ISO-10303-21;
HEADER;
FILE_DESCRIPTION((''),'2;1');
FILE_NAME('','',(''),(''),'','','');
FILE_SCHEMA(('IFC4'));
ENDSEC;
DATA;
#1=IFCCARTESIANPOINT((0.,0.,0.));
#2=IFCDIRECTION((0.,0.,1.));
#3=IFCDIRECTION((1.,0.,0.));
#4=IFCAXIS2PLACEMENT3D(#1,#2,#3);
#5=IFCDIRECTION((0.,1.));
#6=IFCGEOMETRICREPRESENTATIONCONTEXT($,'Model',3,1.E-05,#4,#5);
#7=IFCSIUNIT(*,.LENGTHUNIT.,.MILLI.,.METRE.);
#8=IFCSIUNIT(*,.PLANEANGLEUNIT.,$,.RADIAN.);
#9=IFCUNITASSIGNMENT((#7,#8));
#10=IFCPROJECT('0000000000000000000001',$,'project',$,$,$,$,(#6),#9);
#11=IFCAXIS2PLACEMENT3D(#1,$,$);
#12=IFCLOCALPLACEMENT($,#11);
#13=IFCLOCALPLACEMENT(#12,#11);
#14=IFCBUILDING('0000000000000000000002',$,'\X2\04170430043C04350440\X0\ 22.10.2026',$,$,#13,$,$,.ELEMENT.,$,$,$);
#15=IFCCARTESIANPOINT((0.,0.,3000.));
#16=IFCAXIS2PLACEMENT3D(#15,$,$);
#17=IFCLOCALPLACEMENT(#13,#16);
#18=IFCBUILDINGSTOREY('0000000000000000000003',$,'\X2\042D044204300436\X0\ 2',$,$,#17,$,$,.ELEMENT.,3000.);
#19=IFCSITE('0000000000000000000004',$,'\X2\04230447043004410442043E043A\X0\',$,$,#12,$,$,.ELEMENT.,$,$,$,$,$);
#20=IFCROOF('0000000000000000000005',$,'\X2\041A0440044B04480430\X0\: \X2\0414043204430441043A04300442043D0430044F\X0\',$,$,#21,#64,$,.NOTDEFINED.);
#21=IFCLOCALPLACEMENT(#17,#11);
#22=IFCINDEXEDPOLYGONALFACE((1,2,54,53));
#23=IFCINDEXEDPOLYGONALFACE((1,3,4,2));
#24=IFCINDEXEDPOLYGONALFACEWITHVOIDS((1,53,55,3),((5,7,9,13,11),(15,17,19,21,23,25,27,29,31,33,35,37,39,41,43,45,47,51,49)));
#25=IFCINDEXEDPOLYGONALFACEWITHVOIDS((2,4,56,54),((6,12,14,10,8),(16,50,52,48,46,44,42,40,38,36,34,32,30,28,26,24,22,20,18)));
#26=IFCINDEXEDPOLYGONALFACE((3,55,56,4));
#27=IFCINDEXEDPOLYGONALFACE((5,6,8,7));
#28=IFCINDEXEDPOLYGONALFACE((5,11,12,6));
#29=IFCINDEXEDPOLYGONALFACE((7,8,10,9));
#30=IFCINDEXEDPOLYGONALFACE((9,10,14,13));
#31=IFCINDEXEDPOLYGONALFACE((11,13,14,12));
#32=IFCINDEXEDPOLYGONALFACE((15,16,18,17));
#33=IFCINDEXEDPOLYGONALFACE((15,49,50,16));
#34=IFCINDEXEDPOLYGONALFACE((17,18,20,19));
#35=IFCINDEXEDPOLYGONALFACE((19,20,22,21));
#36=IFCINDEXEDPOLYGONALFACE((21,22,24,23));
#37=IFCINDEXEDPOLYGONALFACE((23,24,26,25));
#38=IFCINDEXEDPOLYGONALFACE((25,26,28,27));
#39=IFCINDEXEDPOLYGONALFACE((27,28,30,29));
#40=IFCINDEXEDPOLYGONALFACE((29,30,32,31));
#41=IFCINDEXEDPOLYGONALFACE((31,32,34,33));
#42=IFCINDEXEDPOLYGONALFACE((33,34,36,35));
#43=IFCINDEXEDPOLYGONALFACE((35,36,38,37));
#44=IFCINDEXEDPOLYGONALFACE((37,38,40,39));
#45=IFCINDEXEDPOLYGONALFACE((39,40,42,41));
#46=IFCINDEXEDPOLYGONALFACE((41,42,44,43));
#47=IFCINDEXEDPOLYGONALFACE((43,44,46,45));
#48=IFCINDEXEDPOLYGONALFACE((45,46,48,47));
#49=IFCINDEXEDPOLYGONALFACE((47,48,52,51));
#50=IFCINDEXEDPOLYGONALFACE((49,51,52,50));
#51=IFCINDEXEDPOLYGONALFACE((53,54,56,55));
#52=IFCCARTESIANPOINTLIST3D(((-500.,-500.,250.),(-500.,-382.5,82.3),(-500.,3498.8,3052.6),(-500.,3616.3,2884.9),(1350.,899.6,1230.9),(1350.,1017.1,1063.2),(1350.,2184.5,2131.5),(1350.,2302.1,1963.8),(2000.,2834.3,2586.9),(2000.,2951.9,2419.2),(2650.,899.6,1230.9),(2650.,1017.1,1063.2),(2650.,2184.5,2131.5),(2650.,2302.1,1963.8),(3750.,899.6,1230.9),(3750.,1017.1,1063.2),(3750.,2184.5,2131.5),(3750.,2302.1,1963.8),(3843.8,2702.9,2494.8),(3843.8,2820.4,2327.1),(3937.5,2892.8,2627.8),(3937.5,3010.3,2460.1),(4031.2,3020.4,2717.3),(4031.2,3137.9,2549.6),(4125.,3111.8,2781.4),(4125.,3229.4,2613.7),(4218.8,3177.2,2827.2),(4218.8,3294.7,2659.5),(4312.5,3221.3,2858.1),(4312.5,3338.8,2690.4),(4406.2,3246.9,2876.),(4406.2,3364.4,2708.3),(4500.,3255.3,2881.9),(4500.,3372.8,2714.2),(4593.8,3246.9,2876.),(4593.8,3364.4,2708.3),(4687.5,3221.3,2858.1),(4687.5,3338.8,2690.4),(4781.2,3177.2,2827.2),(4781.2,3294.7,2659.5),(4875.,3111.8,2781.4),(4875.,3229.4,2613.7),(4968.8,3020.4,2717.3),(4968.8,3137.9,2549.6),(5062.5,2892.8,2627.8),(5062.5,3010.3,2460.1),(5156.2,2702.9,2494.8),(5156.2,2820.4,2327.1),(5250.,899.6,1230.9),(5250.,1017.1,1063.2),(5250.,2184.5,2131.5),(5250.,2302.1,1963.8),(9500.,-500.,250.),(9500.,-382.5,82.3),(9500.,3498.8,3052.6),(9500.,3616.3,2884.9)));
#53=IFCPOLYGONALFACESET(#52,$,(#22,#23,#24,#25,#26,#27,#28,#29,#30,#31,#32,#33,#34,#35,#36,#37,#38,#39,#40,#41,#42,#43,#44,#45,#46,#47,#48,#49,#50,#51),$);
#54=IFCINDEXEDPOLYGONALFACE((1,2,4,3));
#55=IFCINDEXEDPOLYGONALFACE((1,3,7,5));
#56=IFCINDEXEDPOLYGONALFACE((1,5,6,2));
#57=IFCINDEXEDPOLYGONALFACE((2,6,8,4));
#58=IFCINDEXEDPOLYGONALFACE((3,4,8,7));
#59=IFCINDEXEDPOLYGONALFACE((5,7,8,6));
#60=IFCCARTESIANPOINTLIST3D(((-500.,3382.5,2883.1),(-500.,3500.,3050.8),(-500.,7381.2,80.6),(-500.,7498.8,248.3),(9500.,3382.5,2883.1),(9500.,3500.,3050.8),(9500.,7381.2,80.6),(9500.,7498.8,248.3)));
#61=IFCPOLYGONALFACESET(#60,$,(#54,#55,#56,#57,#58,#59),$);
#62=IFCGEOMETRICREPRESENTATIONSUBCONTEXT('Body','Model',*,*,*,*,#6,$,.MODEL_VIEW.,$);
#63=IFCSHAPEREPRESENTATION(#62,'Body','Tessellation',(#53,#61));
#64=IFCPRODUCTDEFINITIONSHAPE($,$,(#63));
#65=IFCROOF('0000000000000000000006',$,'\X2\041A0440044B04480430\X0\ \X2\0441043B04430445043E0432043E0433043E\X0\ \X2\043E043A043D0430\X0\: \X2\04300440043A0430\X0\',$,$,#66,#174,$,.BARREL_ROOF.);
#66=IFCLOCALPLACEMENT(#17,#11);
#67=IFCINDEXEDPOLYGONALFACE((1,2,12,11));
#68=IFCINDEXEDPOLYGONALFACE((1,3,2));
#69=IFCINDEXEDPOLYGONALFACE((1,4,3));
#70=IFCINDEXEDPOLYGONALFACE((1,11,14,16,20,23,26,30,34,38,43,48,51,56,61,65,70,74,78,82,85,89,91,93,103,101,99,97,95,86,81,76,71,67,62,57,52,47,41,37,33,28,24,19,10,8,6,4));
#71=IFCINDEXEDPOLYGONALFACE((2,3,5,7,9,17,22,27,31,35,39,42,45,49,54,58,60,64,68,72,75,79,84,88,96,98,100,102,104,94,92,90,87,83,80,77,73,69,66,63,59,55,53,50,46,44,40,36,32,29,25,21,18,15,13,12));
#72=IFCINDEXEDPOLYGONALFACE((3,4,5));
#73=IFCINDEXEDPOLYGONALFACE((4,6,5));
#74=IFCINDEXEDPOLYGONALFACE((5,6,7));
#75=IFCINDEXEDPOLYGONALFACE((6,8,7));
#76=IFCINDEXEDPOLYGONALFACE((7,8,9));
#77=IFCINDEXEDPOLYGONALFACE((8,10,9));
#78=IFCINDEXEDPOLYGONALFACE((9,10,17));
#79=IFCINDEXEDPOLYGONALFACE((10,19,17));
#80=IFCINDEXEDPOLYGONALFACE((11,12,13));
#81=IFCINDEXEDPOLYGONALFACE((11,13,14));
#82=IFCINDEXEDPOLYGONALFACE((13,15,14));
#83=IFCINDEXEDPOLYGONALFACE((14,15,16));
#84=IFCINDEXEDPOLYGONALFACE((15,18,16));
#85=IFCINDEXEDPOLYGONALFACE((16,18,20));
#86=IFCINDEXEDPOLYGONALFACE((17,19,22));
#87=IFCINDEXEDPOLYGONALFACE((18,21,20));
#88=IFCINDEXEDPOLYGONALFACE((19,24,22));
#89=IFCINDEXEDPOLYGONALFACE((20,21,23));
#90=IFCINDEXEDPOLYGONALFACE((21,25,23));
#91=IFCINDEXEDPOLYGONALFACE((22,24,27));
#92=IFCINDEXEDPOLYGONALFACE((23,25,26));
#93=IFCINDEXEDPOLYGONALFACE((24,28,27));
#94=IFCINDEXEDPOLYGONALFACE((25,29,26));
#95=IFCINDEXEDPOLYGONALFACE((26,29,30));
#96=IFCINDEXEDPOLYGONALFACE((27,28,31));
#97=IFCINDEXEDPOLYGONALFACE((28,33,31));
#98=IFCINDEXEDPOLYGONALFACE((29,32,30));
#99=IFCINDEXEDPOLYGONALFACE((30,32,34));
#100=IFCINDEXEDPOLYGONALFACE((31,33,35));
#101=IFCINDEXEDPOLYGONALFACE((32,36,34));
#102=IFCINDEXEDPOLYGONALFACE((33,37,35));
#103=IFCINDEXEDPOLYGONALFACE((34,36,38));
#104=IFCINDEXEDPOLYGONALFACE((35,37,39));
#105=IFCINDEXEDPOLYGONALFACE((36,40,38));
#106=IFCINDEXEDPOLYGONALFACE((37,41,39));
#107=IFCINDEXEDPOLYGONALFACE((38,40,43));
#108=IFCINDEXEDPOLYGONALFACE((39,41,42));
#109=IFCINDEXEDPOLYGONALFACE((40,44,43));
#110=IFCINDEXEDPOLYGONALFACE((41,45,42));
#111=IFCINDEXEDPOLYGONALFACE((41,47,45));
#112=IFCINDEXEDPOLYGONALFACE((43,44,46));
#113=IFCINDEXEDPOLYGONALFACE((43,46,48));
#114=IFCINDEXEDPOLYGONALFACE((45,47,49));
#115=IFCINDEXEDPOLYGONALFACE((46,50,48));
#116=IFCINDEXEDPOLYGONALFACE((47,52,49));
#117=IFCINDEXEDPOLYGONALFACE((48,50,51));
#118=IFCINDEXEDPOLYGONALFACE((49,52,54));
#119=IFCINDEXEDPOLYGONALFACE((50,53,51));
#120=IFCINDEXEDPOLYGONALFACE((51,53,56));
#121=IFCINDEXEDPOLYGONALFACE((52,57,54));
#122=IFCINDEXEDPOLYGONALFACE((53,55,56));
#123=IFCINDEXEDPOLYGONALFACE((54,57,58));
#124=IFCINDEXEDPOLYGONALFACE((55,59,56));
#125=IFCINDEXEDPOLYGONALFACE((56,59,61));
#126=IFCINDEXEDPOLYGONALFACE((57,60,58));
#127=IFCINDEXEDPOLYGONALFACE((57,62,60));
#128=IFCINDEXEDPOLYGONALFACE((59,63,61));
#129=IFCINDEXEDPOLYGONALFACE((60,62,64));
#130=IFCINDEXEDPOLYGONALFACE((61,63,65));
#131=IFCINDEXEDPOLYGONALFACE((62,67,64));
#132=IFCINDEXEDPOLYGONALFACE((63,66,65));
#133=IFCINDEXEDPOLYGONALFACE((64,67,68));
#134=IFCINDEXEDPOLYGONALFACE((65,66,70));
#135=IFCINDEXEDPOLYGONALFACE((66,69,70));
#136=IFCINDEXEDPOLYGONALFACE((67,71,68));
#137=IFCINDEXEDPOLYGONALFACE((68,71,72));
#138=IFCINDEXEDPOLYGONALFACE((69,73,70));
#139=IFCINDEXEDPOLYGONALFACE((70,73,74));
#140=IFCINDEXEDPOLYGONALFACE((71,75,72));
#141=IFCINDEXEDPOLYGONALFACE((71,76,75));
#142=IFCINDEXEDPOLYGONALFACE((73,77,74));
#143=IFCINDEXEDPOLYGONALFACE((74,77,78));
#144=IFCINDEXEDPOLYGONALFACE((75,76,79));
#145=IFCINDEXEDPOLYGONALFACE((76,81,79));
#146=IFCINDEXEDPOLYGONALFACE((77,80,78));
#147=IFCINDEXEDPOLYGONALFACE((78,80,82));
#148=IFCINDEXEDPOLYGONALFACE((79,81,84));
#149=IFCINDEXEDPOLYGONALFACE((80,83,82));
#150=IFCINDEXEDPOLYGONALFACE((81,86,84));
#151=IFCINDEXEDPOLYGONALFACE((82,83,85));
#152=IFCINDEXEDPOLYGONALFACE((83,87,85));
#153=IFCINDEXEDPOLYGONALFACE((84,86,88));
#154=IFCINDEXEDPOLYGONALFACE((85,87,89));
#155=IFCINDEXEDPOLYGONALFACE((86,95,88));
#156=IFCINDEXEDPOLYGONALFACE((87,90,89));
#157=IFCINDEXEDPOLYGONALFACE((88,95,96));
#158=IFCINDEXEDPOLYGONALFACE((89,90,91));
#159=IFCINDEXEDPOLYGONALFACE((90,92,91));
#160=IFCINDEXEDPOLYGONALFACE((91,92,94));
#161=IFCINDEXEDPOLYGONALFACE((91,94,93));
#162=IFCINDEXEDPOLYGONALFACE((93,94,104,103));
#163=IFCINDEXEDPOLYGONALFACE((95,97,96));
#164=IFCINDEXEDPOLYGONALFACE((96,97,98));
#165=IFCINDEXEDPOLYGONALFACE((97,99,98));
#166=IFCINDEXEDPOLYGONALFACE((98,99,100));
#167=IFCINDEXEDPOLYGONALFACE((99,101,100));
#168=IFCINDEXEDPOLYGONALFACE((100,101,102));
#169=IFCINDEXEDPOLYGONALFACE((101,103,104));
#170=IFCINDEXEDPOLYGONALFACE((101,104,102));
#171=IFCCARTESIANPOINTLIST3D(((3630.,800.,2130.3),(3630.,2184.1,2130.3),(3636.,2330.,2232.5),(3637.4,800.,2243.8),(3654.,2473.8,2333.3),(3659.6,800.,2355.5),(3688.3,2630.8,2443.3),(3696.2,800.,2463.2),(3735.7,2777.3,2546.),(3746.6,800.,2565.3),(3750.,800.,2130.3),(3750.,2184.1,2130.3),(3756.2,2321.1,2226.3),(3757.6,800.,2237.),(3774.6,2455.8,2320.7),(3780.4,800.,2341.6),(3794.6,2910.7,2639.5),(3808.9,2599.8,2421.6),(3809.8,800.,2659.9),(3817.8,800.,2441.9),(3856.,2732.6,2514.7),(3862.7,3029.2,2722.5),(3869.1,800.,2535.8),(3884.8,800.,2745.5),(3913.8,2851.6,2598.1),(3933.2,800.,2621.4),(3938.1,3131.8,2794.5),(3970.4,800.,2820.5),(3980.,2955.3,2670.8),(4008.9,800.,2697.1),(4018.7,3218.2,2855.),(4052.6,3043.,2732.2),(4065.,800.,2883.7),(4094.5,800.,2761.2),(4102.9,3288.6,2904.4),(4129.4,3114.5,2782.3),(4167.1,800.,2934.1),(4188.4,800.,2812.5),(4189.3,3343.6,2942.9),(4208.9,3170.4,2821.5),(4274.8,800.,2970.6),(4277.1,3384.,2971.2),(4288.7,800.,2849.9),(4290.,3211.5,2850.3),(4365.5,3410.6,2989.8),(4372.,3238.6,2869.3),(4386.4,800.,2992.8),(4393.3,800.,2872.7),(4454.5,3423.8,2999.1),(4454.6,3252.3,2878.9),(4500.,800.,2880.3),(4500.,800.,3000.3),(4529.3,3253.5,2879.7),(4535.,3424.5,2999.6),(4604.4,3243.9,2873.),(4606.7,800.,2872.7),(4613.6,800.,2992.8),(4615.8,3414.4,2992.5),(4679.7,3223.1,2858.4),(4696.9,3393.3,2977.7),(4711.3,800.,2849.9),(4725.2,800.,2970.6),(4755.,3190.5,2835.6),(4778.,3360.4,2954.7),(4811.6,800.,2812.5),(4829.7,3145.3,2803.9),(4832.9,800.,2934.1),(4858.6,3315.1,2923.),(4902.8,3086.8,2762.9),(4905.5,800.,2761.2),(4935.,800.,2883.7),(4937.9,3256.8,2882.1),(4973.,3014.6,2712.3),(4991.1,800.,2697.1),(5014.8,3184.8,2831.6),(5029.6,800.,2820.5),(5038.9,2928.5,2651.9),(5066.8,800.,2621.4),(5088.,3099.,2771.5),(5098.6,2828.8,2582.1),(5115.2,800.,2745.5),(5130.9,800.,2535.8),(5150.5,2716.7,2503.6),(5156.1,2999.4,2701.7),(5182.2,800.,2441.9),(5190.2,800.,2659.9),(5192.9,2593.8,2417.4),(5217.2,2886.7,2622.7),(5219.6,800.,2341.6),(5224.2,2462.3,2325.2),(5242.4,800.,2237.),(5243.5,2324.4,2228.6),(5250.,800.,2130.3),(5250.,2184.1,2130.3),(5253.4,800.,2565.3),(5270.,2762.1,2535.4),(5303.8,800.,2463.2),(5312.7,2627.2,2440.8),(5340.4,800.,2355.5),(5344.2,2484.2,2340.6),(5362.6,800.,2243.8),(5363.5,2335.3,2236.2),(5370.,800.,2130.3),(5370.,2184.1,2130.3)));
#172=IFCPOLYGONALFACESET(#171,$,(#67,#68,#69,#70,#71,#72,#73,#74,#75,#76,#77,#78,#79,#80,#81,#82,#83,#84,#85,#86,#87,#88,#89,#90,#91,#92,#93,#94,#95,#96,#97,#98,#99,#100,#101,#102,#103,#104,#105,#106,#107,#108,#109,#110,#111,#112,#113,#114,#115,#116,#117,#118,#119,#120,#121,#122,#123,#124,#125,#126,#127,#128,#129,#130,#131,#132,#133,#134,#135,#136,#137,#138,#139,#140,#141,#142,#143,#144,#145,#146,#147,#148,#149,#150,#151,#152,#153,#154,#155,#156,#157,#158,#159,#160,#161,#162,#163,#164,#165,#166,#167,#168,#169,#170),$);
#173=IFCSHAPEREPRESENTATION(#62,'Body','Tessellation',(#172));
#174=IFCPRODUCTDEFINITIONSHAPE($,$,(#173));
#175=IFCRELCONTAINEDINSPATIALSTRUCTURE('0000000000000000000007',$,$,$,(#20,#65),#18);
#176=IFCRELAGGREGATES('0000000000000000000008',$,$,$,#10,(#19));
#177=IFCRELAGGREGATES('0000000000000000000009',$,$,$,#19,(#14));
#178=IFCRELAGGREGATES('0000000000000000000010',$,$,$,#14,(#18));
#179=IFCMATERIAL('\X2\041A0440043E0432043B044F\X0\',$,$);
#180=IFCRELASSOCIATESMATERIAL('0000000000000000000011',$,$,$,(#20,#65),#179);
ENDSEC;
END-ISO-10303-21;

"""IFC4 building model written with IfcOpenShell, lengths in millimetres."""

from ifc_helpers import new_model, si_unit, point, direction, frame, frame_2d, origin, origin_with_axes, place, context, subcontext, project, spatial, polyline, circle_curve, parameter, trimmed, segment, composite_curve, outline, extrude, clip, halfspace, material, element, save


model = new_model("IFC4")

# Units and contexts
model_context = context("Model", 3, precision=1e-05, world=origin_with_axes(), true_north=direction((0.0, 1.0)))
body_context = subcontext(model_context, "Body", "Model", "MODEL_VIEW")
ifc_project = project(units=[si_unit("LENGTHUNIT", "METRE", prefix="MILLI"), si_unit("PLANEANGLEUNIT", "RADIAN")], contexts=[model_context])

# Site, building, storey
site_placement = place(None, origin())
site = spatial("IfcSite", under=ifc_project, at=site_placement, Name="Участок", CompositionType="ELEMENT")
building_placement = place(site_placement, origin())
building = spatial("IfcBuilding", under=site, at=building_placement, Name="Замер 22.10.2026", CompositionType="ELEMENT")
storey_placement = place(building_placement, frame((0.0, 0.0, 3000.0)))
storey = spatial("IfcBuildingStorey", under=building, at=storey_placement, Name="Этаж 2", CompositionType="ELEMENT", Elevation=3000.0)

# Roofs
ifc_material = material(Name="Кровля")
roof_1_placement = place(storey_placement, origin())
element("IfcRoof", 1, at=roof_1_placement, inside=storey, material=ifc_material, Name="Крыша: Двускатная", PredefinedType="NOTDEFINED", context=body_context, shape_type="SweptSolid", body=[
    extrude(outline(polyline([(0.0, 0.0), (0.0, -10000.0), (4883.1, -10000.0), (4883.1, 0.0), (0.0, 0.0)]), holes=[polyline([(1709.1, -5750.0), (1709.1, -4250.0), (3278.2, -4250.0), (3911.2, -4343.8), (4143.1, -4437.5), (4298.9, -4531.2), (4410.6, -4625.0), (4490.4, -4718.8), (4544.2, -4812.5), (4575.5, -4906.2), (4585.8, -5000.0), (4575.5, -5093.8), (4544.2, -5187.5), (4490.4, -5281.2), (4410.6, -5375.0), (4298.9, -5468.8), (4143.1, -5562.5), (3911.2, -5656.2), (3278.2, -5750.0), (1709.1, -5750.0)]), polyline([(1709.1, -3150.0), (1709.1, -1850.0), (3278.2, -1850.0), (4071.7, -2500.0), (3278.2, -3150.0), (1709.1, -3150.0)])]), frame((-500.0, -500.0, 250.0), z_axis=(0.0, -0.574, 0.819), x_axis=(0.0, 0.819, 0.574)), (0.0, 0.0, -1.0), 204.8),
    extrude(outline(polyline([(0.0, 0.0), (0.0, -10000.0), (4883.1, -10000.0), (4883.1, 0.0), (0.0, 0.0)])), frame((-500.0, 3500.0, 3050.8), z_axis=(0.0, 0.574, 0.819), x_axis=(0.0, 0.819, -0.574)), (0.0, 0.0, -1.0), 204.8),
])
roof_2_placement = place(storey_placement, origin())
element("IfcRoof", 2, at=roof_2_placement, inside=storey, material=ifc_material, Name="Крыша слухового окна: арка", PredefinedType="BARREL_ROOF", context=body_context, shape_type="Clipping", body=[
    clip(extrude(outline(composite_curve([segment(trimmed(circle_curve(frame_2d((0.0, 900.0)), 870.0), [point((870.0, 900.0)), parameter(0.0)], [point((-870.0, 900.0)), parameter(3.141593)], True, "PARAMETER"), True, "CONTINUOUS"), segment(polyline([(-870.0, 900.0), (-750.0, 900.0)]), True, "CONTINUOUS"), segment(trimmed(circle_curve(frame_2d((0.0, 900.0)), 750.0), [point((-750.0, 900.0)), parameter(3.141593)], [point((750.0, 900.0)), parameter(0.0)], False, "PARAMETER"), True, "CONTINUOUS"), segment(polyline([(750.0, 900.0), (870.0, 900.0)]), True, "CONTINUOUS")], self_intersect=False)), frame((4500.0, 800.0, 1230.3), z_axis=(0.0, 1.0, 0.0), x_axis=(-1.0, 0.0, 0.0)), (0.0, 0.0, 1.0), 2699.0), halfspace(frame((4500.0, 900.0, 1230.3), z_axis=(0.0, -0.574, 0.819)), True)),
])

save(model, "model.ifc")
